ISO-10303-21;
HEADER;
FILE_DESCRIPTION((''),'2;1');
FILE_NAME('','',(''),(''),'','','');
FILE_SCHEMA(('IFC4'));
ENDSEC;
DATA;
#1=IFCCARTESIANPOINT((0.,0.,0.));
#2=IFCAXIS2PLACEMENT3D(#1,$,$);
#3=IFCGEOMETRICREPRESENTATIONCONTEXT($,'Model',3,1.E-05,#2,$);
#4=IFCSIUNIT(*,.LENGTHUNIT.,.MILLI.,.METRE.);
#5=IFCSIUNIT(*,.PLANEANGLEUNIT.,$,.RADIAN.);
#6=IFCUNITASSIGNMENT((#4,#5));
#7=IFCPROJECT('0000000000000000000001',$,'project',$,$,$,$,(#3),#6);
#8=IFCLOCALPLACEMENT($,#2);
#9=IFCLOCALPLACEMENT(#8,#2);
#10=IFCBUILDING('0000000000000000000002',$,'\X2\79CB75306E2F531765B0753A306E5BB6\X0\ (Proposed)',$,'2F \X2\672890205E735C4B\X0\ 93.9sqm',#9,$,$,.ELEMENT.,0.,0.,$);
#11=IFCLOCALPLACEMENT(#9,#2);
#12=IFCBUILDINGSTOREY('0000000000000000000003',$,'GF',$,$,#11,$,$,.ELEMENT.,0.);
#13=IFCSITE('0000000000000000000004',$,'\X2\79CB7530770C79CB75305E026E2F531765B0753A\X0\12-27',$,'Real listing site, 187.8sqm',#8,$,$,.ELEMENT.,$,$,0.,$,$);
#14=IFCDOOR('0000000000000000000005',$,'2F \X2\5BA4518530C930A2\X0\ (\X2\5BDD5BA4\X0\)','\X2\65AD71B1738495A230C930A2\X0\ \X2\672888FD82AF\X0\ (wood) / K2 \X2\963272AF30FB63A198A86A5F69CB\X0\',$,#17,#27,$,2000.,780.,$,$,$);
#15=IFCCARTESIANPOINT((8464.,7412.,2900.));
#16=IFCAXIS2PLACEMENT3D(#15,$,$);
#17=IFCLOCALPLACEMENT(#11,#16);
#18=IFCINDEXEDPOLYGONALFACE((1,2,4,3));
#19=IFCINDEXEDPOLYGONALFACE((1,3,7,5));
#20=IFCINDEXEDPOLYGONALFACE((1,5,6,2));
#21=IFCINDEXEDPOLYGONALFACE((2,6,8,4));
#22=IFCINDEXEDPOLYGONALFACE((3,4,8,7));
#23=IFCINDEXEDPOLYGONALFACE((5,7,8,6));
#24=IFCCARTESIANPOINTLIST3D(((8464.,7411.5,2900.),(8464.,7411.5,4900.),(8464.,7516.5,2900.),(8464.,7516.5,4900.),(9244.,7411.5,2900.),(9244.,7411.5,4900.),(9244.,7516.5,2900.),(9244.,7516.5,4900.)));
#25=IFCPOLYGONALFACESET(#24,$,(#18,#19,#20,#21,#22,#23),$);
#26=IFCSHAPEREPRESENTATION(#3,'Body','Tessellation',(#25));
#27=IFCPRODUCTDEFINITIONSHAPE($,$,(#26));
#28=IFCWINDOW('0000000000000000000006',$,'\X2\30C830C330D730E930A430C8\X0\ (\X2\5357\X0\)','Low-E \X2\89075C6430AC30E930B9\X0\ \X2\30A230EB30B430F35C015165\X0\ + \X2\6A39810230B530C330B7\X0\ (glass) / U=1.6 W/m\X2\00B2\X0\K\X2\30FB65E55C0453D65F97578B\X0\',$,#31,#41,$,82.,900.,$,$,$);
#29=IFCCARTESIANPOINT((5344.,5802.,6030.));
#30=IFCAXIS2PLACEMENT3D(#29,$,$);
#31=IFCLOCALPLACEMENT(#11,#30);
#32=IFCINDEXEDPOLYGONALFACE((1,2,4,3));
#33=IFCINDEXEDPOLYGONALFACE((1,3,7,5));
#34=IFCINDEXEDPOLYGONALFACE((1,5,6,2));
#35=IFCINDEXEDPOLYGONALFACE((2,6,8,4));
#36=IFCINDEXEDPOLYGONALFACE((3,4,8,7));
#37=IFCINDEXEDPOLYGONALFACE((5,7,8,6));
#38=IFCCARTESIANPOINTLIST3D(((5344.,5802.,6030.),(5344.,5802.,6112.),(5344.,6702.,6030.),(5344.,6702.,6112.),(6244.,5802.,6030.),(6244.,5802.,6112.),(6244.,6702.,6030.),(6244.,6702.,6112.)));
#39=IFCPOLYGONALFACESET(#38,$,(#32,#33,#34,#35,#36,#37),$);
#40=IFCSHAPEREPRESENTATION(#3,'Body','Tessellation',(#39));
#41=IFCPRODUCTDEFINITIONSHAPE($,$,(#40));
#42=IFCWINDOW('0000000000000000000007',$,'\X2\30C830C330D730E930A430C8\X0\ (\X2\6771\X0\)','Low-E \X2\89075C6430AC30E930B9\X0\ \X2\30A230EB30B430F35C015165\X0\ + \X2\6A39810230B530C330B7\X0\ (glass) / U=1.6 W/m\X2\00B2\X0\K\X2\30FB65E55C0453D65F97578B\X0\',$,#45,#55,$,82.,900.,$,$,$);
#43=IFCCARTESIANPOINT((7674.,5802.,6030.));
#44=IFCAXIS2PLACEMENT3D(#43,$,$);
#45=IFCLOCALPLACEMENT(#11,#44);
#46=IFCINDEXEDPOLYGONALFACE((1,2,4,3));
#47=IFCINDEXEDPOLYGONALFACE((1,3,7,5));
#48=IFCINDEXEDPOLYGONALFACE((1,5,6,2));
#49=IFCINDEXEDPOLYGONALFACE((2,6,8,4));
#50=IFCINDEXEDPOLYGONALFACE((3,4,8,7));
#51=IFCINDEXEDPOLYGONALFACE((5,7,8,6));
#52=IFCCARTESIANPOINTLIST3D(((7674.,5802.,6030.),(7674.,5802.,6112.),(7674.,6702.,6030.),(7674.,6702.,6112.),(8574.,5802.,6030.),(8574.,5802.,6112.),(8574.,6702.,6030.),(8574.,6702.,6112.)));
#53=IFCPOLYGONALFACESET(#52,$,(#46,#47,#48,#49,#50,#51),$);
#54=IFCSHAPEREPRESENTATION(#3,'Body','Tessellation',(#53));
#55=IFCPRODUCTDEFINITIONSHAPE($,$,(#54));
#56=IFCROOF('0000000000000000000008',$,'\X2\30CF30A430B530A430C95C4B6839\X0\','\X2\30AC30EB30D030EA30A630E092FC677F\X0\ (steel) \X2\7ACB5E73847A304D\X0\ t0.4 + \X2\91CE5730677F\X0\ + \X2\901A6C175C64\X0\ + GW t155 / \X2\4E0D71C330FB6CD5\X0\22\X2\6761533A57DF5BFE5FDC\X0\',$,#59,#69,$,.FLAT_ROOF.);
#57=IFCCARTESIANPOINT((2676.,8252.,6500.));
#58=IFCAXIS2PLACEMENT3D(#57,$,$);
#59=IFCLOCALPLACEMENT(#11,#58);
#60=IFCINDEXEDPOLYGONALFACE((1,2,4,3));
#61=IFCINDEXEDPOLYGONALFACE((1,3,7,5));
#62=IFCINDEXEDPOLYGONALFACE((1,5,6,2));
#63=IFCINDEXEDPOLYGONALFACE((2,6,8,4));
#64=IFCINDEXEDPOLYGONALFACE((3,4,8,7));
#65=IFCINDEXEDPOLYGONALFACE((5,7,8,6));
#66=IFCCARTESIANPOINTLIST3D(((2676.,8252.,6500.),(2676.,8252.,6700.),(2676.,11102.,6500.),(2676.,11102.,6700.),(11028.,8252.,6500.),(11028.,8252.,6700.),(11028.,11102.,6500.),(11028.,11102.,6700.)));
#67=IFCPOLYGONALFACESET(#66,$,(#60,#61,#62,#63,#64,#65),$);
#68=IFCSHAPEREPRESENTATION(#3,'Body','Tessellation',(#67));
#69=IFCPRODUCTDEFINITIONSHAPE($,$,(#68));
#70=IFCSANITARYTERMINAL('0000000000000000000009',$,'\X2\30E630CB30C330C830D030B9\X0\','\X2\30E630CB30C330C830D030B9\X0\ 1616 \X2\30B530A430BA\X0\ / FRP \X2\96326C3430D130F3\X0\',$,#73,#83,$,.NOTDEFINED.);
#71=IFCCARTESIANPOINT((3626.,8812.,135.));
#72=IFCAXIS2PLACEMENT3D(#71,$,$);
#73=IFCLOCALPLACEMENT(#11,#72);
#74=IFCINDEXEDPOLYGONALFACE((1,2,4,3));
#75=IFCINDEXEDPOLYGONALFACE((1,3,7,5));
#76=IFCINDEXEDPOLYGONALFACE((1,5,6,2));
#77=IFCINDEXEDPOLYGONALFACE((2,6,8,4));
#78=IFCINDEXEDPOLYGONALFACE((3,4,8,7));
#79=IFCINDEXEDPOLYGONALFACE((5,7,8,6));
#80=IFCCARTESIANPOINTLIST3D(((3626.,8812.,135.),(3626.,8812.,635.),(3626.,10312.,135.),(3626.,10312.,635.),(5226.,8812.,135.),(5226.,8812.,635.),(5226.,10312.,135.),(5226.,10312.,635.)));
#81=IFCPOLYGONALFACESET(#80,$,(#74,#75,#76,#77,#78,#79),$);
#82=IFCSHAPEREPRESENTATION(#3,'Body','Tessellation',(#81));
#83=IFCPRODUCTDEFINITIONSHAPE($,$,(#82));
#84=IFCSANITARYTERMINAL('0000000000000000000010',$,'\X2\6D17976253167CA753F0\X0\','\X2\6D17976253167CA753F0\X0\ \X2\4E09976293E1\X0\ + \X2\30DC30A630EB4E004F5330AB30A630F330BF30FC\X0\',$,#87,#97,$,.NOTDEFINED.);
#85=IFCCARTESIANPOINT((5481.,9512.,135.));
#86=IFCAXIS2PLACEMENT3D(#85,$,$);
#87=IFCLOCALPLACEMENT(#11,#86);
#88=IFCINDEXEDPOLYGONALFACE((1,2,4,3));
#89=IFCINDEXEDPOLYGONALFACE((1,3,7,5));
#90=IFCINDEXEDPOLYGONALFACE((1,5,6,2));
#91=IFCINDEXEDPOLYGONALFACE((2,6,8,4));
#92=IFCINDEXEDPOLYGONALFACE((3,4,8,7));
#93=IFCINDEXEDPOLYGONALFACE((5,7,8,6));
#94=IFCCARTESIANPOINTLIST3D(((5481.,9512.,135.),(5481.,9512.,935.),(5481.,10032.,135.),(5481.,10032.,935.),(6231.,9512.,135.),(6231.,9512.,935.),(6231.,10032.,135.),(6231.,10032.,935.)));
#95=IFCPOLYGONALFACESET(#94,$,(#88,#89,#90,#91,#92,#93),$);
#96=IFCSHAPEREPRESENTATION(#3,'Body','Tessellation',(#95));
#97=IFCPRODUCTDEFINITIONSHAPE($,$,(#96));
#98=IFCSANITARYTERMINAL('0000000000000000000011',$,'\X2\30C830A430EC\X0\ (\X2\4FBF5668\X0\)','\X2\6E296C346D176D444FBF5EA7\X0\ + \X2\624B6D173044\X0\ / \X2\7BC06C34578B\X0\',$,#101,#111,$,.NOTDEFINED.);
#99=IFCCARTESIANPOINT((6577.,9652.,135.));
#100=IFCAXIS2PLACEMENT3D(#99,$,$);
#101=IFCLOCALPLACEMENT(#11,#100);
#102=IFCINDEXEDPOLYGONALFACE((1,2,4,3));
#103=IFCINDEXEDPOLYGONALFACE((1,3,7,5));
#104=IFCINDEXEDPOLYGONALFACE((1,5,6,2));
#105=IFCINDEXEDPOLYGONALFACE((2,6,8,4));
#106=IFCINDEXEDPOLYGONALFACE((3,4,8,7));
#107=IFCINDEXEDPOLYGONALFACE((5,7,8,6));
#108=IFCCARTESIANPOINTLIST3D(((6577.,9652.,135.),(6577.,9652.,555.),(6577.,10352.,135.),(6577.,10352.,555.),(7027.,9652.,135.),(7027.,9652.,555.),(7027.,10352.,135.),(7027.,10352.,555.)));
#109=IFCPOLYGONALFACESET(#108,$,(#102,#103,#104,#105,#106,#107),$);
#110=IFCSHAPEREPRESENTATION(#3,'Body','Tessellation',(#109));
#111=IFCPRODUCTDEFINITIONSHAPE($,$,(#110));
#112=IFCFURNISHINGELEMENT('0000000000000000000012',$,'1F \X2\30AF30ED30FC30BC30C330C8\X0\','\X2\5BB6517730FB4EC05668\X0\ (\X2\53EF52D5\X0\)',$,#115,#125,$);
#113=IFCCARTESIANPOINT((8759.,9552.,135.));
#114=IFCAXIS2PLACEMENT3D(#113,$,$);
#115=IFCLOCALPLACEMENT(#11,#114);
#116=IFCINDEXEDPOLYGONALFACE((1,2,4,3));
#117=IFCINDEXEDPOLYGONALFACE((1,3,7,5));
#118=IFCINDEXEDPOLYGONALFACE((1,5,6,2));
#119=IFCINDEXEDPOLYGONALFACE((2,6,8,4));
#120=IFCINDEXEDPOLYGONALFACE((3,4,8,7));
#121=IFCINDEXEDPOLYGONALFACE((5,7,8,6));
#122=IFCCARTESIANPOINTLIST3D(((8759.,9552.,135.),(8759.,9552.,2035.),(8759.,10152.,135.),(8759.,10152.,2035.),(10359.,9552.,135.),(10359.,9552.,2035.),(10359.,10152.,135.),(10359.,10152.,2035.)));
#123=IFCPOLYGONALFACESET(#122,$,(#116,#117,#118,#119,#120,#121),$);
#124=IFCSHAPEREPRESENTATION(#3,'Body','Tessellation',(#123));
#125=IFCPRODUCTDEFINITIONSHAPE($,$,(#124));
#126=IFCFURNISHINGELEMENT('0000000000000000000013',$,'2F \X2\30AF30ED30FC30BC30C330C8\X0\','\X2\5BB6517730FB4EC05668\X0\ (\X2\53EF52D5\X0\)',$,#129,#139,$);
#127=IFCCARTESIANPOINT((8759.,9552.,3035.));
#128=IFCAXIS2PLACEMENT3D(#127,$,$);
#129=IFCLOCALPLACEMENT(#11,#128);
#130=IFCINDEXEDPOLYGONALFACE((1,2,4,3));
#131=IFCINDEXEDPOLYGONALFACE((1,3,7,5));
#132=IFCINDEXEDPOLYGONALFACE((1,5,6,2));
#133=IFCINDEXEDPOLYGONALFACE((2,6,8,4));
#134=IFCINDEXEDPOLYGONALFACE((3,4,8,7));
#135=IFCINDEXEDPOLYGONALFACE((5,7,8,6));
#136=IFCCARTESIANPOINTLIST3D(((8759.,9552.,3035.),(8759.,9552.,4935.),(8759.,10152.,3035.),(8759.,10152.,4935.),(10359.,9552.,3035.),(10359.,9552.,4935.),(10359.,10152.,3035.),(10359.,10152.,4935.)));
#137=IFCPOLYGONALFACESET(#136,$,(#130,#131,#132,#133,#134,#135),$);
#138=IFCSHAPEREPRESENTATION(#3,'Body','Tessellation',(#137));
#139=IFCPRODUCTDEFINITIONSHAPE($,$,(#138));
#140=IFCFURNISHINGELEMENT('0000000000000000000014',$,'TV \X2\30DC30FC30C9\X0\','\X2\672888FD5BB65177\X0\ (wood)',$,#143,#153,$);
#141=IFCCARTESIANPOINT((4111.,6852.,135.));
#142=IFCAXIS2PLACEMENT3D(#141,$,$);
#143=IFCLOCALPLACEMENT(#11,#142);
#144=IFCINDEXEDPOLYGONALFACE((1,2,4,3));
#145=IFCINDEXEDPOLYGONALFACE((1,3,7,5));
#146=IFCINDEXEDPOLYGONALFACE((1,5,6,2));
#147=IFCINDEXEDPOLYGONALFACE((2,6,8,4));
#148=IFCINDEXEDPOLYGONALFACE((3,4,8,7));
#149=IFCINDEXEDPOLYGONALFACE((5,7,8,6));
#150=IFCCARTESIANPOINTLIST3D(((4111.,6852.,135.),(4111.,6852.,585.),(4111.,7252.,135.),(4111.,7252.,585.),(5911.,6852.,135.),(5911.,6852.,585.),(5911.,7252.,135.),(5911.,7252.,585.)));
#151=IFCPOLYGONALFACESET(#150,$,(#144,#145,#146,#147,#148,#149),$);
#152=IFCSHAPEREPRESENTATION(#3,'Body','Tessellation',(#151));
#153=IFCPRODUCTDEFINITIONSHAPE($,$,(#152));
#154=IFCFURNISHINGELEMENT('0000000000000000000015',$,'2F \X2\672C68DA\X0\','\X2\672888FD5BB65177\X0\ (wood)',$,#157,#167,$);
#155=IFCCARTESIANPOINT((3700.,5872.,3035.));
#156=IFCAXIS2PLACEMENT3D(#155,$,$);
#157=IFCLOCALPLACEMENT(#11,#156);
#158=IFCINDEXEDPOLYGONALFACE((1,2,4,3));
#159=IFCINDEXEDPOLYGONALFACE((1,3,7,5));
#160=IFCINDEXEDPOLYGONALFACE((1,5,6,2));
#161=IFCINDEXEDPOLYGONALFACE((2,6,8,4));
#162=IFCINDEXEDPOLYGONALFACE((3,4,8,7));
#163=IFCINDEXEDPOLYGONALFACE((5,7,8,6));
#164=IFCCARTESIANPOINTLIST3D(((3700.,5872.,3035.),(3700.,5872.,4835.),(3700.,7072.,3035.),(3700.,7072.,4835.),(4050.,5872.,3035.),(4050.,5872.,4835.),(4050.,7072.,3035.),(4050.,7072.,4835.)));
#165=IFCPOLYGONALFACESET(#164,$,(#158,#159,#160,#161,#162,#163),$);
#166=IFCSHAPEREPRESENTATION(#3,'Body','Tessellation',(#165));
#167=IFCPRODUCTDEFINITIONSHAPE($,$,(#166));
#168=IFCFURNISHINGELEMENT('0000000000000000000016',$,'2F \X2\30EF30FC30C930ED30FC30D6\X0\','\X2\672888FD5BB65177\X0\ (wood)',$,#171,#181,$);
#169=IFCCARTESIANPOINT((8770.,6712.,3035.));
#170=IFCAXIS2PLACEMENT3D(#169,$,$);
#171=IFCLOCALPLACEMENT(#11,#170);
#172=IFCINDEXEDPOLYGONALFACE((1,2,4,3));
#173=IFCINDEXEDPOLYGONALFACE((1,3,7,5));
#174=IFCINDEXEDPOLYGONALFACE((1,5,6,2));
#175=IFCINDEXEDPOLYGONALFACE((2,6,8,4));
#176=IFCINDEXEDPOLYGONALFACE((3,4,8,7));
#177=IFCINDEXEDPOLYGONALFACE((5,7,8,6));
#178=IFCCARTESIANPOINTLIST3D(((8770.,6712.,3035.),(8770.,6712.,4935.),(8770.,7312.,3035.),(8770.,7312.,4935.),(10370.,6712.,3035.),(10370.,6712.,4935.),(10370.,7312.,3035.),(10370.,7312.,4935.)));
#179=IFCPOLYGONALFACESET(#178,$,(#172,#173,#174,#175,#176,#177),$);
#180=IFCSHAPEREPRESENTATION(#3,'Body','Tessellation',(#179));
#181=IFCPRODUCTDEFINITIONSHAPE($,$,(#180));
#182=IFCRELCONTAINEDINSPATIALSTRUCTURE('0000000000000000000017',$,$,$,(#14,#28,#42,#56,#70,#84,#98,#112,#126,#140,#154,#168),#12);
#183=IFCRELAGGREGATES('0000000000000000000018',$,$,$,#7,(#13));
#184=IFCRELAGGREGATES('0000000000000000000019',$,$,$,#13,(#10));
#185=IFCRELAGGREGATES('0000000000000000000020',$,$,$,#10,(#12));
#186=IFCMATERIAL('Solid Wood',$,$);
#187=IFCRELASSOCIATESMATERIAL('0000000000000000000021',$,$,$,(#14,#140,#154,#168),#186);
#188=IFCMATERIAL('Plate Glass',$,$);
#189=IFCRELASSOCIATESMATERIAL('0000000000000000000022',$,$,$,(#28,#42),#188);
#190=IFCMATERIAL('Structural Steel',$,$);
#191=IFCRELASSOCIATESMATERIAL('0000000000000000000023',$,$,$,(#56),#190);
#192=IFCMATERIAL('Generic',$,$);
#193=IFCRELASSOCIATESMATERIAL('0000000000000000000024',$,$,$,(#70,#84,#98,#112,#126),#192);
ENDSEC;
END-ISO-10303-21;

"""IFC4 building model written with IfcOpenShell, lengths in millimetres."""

from ifc_helpers import new_model, si_unit, frame, frame_2d, origin, place, context, project, spatial, rectangle, extrude, material, element, save


model = new_model("IFC4")

# Units and contexts
model_context = context("Model", 3, precision=1e-05, world=origin())
ifc_project = project(units=[si_unit("LENGTHUNIT", "METRE", prefix="MILLI"), si_unit("PLANEANGLEUNIT", "RADIAN")], contexts=[model_context])

# Site, building, storey
site_placement = place(None, origin())
site = spatial("IfcSite", under=ifc_project, at=site_placement, Name="秋田県秋田市港北新町12-27", ObjectType="Real listing site, 187.8sqm", CompositionType="ELEMENT", RefElevation=0.0)
building_placement = place(site_placement, origin())
building = spatial("IfcBuilding", under=site, at=building_placement, Name="秋田港北新町の家 (Proposed)", ObjectType="2F 木造平屋 93.9sqm", CompositionType="ELEMENT", ElevationOfRefHeight=0.0, ElevationOfTerrain=0.0)
storey_placement = place(building_placement, origin())
storey = spatial("IfcBuildingStorey", under=building, at=storey_placement, Name="GF", CompositionType="ELEMENT", Elevation=0.0)

# Shared definitions
ifc_material_1 = material(Name="Solid Wood")
ifc_material_2 = material(Name="Plate Glass")

# Door
door_1_placement = place(storey_placement, frame((8464.0, 7412.0, 2900.0)))
element("IfcDoor", 1, at=door_1_placement, inside=storey, material=ifc_material_1, Name="2F 室内ドア (寝室)", Description="断熱玄関ドア 木製芯 (wood) / K2 防犯・採風機構", OverallHeight=2000.0, OverallWidth=780.0, context=model_context, shape_type="SweptSolid", body=[
    extrude(rectangle(XDim=780.0, YDim=105.0, at=frame_2d((390.0, 52.0))), frame((8464.0, 7412.0, 2900.0)), (0.0, 0.0, 1.0), 2000.0),
])

# Windows
window_1_placement = place(storey_placement, frame((5344.0, 5802.0, 6030.0)))
element("IfcWindow", 2, at=window_1_placement, inside=storey, material=ifc_material_2, Name="トップライト (南)", Description="Low-E 複層ガラス アルゴン封入 + 樹脂サッシ (glass) / U=1.6 W/m²K・日射取得型", OverallHeight=82.0, OverallWidth=900.0, context=model_context, shape_type="SweptSolid", body=[
    extrude(rectangle(XDim=900.0, YDim=900.0, at=frame_2d((450.0, 450.0))), frame((5344.0, 5802.0, 6030.0)), (0.0, 0.0, 1.0), 82.0),
])
window_2_placement = place(storey_placement, frame((7674.0, 5802.0, 6030.0)))
element("IfcWindow", 3, at=window_2_placement, inside=storey, material=ifc_material_2, Name="トップライト (東)", Description="Low-E 複層ガラス アルゴン封入 + 樹脂サッシ (glass) / U=1.6 W/m²K・日射取得型", OverallHeight=82.0, OverallWidth=900.0, context=model_context, shape_type="SweptSolid", body=[
    extrude(rectangle(XDim=900.0, YDim=900.0, at=frame_2d((450.0, 450.0))), frame((7674.0, 5802.0, 6030.0)), (0.0, 0.0, 1.0), 82.0),
])

# Roof
ifc_material_3 = material(Name="Structural Steel")
roof_placement = place(storey_placement, frame((2676.0, 8252.0, 6500.0)))
element("IfcRoof", 4, at=roof_placement, inside=storey, material=ifc_material_3, Name="ハイサイド屋根", Description="ガルバリウム鋼板 (steel) 立平葺き t0.4 + 野地板 + 通気層 + GW t155 / 不燃・法22条区域対応", PredefinedType="FLAT_ROOF", context=model_context, shape_type="SweptSolid", body=[
    extrude(rectangle(XDim=8352.0, YDim=2850.0, at=frame_2d((4176.0, 1425.0))), frame((2676.0, 8252.0, 6500.0)), (0.0, 0.0, 1.0), 200.0),
])

# Sanitary terminals
ifc_material_4 = material(Name="Generic")
sanitary_terminal_1_placement = place(storey_placement, frame((3626.0, 8812.0, 135.0)))
element("IfcSanitaryTerminal", 5, at=sanitary_terminal_1_placement, inside=storey, material=ifc_material_4, Name="ユニットバス", Description="ユニットバス 1616 サイズ / FRP 防水パン", PredefinedType="NOTDEFINED", context=model_context, shape_type="SweptSolid", body=[
    extrude(rectangle(XDim=1600.0, YDim=1500.0, at=frame_2d((800.0, 750.0))), frame((3626.0, 8812.0, 135.0)), (0.0, 0.0, 1.0), 500.0),
])
sanitary_terminal_2_placement = place(storey_placement, frame((5481.0, 9512.0, 135.0)))
element("IfcSanitaryTerminal", 6, at=sanitary_terminal_2_placement, inside=storey, material=ifc_material_4, Name="洗面化粧台", Description="洗面化粧台 三面鏡 + ボウル一体カウンター", PredefinedType="NOTDEFINED", context=model_context, shape_type="SweptSolid", body=[
    extrude(rectangle(XDim=750.0, YDim=520.0, at=frame_2d((375.0, 260.0))), frame((5481.0, 9512.0, 135.0)), (0.0, 0.0, 1.0), 800.0),
])
sanitary_terminal_3_placement = place(storey_placement, frame((6577.0, 9652.0, 135.0)))
element("IfcSanitaryTerminal", 7, at=sanitary_terminal_3_placement, inside=storey, material=ifc_material_4, Name="トイレ (便器)", Description="温水洗浄便座 + 手洗い / 節水型", PredefinedType="NOTDEFINED", context=model_context, shape_type="SweptSolid", body=[
    extrude(rectangle(XDim=450.0, YDim=700.0, at=frame_2d((225.0, 350.0))), frame((6577.0, 9652.0, 135.0)), (0.0, 0.0, 1.0), 420.0),
])

# Furnishing elements
furnishing_1_placement = place(storey_placement, frame((8759.0, 9552.0, 135.0)))
element("IfcFurnishingElement", 8, at=furnishing_1_placement, inside=storey, material=ifc_material_4, Name="1F クローゼット", Description="家具・什器 (可動)", context=model_context, shape_type="SweptSolid", body=[
    extrude(rectangle(XDim=1600.0, YDim=600.0, at=frame_2d((800.0, 300.0))), frame((8759.0, 9552.0, 135.0)), (0.0, 0.0, 1.0), 1900.0),
])
furnishing_2_placement = place(storey_placement, frame((8759.0, 9552.0, 3035.0)))
element("IfcFurnishingElement", 9, at=furnishing_2_placement, inside=storey, material=ifc_material_4, Name="2F クローゼット", Description="家具・什器 (可動)", context=model_context, shape_type="SweptSolid", body=[
    extrude(rectangle(XDim=1600.0, YDim=600.0, at=frame_2d((800.0, 300.0))), frame((8759.0, 9552.0, 3035.0)), (0.0, 0.0, 1.0), 1900.0),
])
furnishing_3_placement = place(storey_placement, frame((4111.0, 6852.0, 135.0)))
element("IfcFurnishingElement", 10, at=furnishing_3_placement, inside=storey, material=ifc_material_1, Name="TV ボード", Description="木製家具 (wood)", context=model_context, shape_type="SweptSolid", body=[
    extrude(rectangle(XDim=1800.0, YDim=400.0, at=frame_2d((900.0, 200.0))), frame((4111.0, 6852.0, 135.0)), (0.0, 0.0, 1.0), 450.0),
])
furnishing_4_placement = place(storey_placement, frame((3700.0, 5872.0, 3035.0)))
element("IfcFurnishingElement", 11, at=furnishing_4_placement, inside=storey, material=ifc_material_1, Name="2F 本棚", Description="木製家具 (wood)", context=model_context, shape_type="SweptSolid", body=[
    extrude(rectangle(XDim=350.0, YDim=1200.0, at=frame_2d((175.0, 600.0))), frame((3700.0, 5872.0, 3035.0)), (0.0, 0.0, 1.0), 1800.0),
])
furnishing_5_placement = place(storey_placement, frame((8770.0, 6712.0, 3035.0)))
element("IfcFurnishingElement", 12, at=furnishing_5_placement, inside=storey, material=ifc_material_1, Name="2F ワードローブ", Description="木製家具 (wood)", context=model_context, shape_type="SweptSolid", body=[
    extrude(rectangle(XDim=1600.0, YDim=600.0, at=frame_2d((800.0, 300.0))), frame((8770.0, 6712.0, 3035.0)), (0.0, 0.0, 1.0), 1900.0),
])

save(model, "model.ifc")
